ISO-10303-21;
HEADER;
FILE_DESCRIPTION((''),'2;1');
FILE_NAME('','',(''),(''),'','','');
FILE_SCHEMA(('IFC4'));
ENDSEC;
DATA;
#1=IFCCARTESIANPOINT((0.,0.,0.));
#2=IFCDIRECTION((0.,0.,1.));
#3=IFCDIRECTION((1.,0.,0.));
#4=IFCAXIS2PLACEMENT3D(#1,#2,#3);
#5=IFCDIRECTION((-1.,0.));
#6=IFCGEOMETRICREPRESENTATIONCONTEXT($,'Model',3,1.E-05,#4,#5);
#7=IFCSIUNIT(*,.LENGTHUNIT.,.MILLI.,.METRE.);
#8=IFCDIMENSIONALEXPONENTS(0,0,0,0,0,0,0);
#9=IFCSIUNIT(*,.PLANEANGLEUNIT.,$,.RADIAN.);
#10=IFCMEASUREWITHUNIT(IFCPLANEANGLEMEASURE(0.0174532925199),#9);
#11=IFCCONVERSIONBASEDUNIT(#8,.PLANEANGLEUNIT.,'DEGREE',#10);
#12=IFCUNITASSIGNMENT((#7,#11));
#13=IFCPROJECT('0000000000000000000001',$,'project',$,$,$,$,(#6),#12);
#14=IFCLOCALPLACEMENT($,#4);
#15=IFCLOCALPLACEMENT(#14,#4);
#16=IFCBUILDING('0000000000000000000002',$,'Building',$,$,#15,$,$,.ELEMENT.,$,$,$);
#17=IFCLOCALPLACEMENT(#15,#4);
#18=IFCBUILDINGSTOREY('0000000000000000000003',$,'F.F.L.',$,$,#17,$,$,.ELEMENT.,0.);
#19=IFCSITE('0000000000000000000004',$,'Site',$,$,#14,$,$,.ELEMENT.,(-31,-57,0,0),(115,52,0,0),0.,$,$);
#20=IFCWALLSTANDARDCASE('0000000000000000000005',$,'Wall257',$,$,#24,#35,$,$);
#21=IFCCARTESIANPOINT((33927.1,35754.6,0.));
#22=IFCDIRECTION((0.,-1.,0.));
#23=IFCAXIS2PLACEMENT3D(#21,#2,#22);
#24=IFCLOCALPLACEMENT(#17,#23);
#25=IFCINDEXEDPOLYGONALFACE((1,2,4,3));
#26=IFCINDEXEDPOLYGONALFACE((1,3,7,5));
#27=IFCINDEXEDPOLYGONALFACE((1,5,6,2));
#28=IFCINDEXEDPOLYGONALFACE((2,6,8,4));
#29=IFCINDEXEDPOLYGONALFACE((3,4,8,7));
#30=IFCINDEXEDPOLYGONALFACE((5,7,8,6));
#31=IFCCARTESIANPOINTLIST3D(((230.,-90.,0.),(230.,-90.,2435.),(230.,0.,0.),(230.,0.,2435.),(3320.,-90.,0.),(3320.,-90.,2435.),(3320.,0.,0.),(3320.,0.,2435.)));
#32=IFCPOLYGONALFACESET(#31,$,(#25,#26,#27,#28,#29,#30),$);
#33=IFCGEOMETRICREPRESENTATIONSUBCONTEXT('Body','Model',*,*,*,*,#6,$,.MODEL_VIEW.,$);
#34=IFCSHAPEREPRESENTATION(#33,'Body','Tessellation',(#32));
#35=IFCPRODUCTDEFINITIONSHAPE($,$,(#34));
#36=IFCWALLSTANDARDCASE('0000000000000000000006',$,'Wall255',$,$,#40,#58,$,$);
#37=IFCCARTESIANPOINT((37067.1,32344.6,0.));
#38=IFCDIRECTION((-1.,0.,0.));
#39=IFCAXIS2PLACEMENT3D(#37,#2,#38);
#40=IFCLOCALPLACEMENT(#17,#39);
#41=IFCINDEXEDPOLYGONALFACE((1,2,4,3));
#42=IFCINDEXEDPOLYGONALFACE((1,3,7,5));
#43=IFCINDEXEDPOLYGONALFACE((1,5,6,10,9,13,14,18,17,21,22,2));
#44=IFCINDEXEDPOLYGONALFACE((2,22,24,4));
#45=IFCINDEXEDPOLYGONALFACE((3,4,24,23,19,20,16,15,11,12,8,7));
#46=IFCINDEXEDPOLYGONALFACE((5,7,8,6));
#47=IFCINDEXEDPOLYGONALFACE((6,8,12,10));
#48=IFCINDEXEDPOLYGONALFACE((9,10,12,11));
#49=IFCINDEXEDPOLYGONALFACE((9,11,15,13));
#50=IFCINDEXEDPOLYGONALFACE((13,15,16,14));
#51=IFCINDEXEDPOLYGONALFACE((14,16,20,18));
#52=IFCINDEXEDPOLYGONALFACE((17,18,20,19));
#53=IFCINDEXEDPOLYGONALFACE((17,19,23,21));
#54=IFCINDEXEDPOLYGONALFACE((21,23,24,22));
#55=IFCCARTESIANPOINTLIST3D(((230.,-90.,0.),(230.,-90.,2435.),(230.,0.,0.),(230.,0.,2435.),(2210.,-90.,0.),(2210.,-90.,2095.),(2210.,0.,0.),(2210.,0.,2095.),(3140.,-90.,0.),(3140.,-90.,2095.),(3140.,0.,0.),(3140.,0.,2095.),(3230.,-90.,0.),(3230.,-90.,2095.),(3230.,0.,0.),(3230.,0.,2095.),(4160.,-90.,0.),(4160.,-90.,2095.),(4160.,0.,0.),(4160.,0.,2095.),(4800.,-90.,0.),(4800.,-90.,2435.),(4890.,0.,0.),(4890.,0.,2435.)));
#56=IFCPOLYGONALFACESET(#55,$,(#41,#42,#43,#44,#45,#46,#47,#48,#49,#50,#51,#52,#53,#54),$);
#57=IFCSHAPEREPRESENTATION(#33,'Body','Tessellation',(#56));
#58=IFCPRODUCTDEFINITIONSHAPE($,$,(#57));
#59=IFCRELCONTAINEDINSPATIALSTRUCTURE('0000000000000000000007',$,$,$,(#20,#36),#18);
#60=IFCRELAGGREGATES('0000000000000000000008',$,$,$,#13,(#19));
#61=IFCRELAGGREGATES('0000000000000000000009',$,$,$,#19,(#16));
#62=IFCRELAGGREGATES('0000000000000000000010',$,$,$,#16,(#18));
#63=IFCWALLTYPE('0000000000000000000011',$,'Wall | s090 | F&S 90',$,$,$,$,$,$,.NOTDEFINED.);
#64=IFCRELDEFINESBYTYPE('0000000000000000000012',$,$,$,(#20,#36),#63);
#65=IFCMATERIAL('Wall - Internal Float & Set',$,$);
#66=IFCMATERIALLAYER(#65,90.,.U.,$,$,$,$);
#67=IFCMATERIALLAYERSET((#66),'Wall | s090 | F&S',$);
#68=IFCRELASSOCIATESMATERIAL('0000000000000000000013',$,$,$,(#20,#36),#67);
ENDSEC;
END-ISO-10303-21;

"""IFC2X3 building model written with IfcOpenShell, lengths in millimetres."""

from ifc_helpers import new_model, entity, si_unit, converted_unit, direction, frame, origin_with_axes, origin_2d_with_axis, place, context, subcontext, project, spatial, polyline, rectangle, outline, extrude, material, layer, layer_set, layer_usage, type_object, element, save


model = new_model("IFC2X3")

# Units and contexts
model_context = context("Model", 3, precision=1e-05, world=origin_with_axes(), true_north=direction((-1.0, 0.0)))
body_context = subcontext(model_context, "Body", "Model", "MODEL_VIEW")
ifc_project = project(units=[si_unit("LENGTHUNIT", "METRE", prefix="MILLI"), converted_unit("PLANEANGLEUNIT", "DEGREE", entity("IfcPlaneAngleMeasure", 0.0174532925199), si_unit("PLANEANGLEUNIT", "RADIAN"), dimensions=[0, 0, 0, 0, 0, 0, 0])], contexts=[model_context])

# Site, building, storey
site_placement = place(None, origin_with_axes())
site = spatial("IfcSite", under=ifc_project, at=site_placement, Name="Site", CompositionType="ELEMENT", RefLatitude=(-31, -57, 0, 0), RefLongitude=(115, 52, 0, 0), RefElevation=0.0)
building_placement = place(site_placement, origin_with_axes())
building = spatial("IfcBuilding", under=site, at=building_placement, Name="Building", CompositionType="ELEMENT")
storey_placement = place(building_placement, origin_with_axes())
storey = spatial("IfcBuildingStorey", under=building, at=storey_placement, Name="F.F.L.", CompositionType="ELEMENT", Elevation=0.0)

# Wall
ifc_material_1 = material(Name="Wall - Internal Float & Set")
ifc_layer_1 = layer(ifc_material_1, 90.0, ventilated="UNKNOWN")
ifc_layer_set_1 = layer_set([ifc_layer_1], Name="Wall | s090 | F&S")
ifc_layer_usage_1 = layer_usage(ifc_layer_set_1, "AXIS2", "POSITIVE", -90.0)
wall_type_1 = type_object("IfcWallType", Name="Wall | s090 | F&S 90", PredefinedType="NOTDEFINED")
wall_1_placement = place(storey_placement, frame((33927.1, 35754.6, 0.0), z_axis=(0.0, 0.0, 1.0), x_axis=(0.0, -1.0, 0.0)))
element("IfcWallStandardCase", 1, at=wall_1_placement, inside=storey, type_object=wall_type_1, material=ifc_layer_usage_1, Name="Wall257", context=body_context, shape_type="SweptSolid", body=[
    extrude(outline(polyline([(230.0, -90.0), (3320.0, -90.0), (3320.0, 0.0), (230.0, 0.0), (230.0, -90.0)])), origin_with_axes(), (0.0, 0.0, 1.0), 2435.0),
])

# Wall, openings
ifc_layer_usage_2 = layer_usage(ifc_layer_set_1, "AXIS2", "POSITIVE", -90.0)
wall_2_placement = place(storey_placement, frame((37067.1, 32344.6, 0.0), z_axis=(0.0, 0.0, 1.0), x_axis=(-1.0, 0.0, 0.0)))
wall_2 = element("IfcWallStandardCase", 2, at=wall_2_placement, inside=storey, type_object=wall_type_1, material=ifc_layer_usage_2, Name="Wall255", context=body_context, shape_type="SweptSolid", body=[
    extrude(outline(polyline([(230.0, -90.0), (4800.0, -90.0), (4890.0, 0.0), (230.0, 0.0), (230.0, -90.0)])), origin_with_axes(), (0.0, 0.0, 1.0), 2435.0),
])
opening_1_placement = place(wall_2_placement, frame((3695.0, 0.0, 0.0), z_axis=(0.0, 0.0, 1.0), x_axis=(1.0, 0.0, 0.0)))
element("IfcOpeningElement", 3, at=opening_1_placement, cuts=wall_2, context=body_context, shape_type="SweptSolid", body=[
    extrude(rectangle(XDim=930.0, YDim=2095.0, at=origin_2d_with_axis()), frame((0.0, 90.0, 1047.5), z_axis=(0.0, -1.0, 0.0), x_axis=(-1.0, 0.0, 0.0)), (0.0, 0.0, 1.0), 180.0),
])
opening_2_placement = place(wall_2_placement, frame((2675.0, 0.0, 0.0), z_axis=(0.0, 0.0, 1.0), x_axis=(1.0, 0.0, 0.0)))
element("IfcOpeningElement", 4, at=opening_2_placement, cuts=wall_2, context=body_context, shape_type="SweptSolid", body=[
    extrude(rectangle(XDim=930.0, YDim=2095.0, at=origin_2d_with_axis()), frame((0.0, 90.0, 1047.5), z_axis=(0.0, 1.0, 0.0), x_axis=(1.0, 0.0, 0.0)), (0.0, 0.0, -1.0), 180.0),
])

save(model, "model.ifc")
